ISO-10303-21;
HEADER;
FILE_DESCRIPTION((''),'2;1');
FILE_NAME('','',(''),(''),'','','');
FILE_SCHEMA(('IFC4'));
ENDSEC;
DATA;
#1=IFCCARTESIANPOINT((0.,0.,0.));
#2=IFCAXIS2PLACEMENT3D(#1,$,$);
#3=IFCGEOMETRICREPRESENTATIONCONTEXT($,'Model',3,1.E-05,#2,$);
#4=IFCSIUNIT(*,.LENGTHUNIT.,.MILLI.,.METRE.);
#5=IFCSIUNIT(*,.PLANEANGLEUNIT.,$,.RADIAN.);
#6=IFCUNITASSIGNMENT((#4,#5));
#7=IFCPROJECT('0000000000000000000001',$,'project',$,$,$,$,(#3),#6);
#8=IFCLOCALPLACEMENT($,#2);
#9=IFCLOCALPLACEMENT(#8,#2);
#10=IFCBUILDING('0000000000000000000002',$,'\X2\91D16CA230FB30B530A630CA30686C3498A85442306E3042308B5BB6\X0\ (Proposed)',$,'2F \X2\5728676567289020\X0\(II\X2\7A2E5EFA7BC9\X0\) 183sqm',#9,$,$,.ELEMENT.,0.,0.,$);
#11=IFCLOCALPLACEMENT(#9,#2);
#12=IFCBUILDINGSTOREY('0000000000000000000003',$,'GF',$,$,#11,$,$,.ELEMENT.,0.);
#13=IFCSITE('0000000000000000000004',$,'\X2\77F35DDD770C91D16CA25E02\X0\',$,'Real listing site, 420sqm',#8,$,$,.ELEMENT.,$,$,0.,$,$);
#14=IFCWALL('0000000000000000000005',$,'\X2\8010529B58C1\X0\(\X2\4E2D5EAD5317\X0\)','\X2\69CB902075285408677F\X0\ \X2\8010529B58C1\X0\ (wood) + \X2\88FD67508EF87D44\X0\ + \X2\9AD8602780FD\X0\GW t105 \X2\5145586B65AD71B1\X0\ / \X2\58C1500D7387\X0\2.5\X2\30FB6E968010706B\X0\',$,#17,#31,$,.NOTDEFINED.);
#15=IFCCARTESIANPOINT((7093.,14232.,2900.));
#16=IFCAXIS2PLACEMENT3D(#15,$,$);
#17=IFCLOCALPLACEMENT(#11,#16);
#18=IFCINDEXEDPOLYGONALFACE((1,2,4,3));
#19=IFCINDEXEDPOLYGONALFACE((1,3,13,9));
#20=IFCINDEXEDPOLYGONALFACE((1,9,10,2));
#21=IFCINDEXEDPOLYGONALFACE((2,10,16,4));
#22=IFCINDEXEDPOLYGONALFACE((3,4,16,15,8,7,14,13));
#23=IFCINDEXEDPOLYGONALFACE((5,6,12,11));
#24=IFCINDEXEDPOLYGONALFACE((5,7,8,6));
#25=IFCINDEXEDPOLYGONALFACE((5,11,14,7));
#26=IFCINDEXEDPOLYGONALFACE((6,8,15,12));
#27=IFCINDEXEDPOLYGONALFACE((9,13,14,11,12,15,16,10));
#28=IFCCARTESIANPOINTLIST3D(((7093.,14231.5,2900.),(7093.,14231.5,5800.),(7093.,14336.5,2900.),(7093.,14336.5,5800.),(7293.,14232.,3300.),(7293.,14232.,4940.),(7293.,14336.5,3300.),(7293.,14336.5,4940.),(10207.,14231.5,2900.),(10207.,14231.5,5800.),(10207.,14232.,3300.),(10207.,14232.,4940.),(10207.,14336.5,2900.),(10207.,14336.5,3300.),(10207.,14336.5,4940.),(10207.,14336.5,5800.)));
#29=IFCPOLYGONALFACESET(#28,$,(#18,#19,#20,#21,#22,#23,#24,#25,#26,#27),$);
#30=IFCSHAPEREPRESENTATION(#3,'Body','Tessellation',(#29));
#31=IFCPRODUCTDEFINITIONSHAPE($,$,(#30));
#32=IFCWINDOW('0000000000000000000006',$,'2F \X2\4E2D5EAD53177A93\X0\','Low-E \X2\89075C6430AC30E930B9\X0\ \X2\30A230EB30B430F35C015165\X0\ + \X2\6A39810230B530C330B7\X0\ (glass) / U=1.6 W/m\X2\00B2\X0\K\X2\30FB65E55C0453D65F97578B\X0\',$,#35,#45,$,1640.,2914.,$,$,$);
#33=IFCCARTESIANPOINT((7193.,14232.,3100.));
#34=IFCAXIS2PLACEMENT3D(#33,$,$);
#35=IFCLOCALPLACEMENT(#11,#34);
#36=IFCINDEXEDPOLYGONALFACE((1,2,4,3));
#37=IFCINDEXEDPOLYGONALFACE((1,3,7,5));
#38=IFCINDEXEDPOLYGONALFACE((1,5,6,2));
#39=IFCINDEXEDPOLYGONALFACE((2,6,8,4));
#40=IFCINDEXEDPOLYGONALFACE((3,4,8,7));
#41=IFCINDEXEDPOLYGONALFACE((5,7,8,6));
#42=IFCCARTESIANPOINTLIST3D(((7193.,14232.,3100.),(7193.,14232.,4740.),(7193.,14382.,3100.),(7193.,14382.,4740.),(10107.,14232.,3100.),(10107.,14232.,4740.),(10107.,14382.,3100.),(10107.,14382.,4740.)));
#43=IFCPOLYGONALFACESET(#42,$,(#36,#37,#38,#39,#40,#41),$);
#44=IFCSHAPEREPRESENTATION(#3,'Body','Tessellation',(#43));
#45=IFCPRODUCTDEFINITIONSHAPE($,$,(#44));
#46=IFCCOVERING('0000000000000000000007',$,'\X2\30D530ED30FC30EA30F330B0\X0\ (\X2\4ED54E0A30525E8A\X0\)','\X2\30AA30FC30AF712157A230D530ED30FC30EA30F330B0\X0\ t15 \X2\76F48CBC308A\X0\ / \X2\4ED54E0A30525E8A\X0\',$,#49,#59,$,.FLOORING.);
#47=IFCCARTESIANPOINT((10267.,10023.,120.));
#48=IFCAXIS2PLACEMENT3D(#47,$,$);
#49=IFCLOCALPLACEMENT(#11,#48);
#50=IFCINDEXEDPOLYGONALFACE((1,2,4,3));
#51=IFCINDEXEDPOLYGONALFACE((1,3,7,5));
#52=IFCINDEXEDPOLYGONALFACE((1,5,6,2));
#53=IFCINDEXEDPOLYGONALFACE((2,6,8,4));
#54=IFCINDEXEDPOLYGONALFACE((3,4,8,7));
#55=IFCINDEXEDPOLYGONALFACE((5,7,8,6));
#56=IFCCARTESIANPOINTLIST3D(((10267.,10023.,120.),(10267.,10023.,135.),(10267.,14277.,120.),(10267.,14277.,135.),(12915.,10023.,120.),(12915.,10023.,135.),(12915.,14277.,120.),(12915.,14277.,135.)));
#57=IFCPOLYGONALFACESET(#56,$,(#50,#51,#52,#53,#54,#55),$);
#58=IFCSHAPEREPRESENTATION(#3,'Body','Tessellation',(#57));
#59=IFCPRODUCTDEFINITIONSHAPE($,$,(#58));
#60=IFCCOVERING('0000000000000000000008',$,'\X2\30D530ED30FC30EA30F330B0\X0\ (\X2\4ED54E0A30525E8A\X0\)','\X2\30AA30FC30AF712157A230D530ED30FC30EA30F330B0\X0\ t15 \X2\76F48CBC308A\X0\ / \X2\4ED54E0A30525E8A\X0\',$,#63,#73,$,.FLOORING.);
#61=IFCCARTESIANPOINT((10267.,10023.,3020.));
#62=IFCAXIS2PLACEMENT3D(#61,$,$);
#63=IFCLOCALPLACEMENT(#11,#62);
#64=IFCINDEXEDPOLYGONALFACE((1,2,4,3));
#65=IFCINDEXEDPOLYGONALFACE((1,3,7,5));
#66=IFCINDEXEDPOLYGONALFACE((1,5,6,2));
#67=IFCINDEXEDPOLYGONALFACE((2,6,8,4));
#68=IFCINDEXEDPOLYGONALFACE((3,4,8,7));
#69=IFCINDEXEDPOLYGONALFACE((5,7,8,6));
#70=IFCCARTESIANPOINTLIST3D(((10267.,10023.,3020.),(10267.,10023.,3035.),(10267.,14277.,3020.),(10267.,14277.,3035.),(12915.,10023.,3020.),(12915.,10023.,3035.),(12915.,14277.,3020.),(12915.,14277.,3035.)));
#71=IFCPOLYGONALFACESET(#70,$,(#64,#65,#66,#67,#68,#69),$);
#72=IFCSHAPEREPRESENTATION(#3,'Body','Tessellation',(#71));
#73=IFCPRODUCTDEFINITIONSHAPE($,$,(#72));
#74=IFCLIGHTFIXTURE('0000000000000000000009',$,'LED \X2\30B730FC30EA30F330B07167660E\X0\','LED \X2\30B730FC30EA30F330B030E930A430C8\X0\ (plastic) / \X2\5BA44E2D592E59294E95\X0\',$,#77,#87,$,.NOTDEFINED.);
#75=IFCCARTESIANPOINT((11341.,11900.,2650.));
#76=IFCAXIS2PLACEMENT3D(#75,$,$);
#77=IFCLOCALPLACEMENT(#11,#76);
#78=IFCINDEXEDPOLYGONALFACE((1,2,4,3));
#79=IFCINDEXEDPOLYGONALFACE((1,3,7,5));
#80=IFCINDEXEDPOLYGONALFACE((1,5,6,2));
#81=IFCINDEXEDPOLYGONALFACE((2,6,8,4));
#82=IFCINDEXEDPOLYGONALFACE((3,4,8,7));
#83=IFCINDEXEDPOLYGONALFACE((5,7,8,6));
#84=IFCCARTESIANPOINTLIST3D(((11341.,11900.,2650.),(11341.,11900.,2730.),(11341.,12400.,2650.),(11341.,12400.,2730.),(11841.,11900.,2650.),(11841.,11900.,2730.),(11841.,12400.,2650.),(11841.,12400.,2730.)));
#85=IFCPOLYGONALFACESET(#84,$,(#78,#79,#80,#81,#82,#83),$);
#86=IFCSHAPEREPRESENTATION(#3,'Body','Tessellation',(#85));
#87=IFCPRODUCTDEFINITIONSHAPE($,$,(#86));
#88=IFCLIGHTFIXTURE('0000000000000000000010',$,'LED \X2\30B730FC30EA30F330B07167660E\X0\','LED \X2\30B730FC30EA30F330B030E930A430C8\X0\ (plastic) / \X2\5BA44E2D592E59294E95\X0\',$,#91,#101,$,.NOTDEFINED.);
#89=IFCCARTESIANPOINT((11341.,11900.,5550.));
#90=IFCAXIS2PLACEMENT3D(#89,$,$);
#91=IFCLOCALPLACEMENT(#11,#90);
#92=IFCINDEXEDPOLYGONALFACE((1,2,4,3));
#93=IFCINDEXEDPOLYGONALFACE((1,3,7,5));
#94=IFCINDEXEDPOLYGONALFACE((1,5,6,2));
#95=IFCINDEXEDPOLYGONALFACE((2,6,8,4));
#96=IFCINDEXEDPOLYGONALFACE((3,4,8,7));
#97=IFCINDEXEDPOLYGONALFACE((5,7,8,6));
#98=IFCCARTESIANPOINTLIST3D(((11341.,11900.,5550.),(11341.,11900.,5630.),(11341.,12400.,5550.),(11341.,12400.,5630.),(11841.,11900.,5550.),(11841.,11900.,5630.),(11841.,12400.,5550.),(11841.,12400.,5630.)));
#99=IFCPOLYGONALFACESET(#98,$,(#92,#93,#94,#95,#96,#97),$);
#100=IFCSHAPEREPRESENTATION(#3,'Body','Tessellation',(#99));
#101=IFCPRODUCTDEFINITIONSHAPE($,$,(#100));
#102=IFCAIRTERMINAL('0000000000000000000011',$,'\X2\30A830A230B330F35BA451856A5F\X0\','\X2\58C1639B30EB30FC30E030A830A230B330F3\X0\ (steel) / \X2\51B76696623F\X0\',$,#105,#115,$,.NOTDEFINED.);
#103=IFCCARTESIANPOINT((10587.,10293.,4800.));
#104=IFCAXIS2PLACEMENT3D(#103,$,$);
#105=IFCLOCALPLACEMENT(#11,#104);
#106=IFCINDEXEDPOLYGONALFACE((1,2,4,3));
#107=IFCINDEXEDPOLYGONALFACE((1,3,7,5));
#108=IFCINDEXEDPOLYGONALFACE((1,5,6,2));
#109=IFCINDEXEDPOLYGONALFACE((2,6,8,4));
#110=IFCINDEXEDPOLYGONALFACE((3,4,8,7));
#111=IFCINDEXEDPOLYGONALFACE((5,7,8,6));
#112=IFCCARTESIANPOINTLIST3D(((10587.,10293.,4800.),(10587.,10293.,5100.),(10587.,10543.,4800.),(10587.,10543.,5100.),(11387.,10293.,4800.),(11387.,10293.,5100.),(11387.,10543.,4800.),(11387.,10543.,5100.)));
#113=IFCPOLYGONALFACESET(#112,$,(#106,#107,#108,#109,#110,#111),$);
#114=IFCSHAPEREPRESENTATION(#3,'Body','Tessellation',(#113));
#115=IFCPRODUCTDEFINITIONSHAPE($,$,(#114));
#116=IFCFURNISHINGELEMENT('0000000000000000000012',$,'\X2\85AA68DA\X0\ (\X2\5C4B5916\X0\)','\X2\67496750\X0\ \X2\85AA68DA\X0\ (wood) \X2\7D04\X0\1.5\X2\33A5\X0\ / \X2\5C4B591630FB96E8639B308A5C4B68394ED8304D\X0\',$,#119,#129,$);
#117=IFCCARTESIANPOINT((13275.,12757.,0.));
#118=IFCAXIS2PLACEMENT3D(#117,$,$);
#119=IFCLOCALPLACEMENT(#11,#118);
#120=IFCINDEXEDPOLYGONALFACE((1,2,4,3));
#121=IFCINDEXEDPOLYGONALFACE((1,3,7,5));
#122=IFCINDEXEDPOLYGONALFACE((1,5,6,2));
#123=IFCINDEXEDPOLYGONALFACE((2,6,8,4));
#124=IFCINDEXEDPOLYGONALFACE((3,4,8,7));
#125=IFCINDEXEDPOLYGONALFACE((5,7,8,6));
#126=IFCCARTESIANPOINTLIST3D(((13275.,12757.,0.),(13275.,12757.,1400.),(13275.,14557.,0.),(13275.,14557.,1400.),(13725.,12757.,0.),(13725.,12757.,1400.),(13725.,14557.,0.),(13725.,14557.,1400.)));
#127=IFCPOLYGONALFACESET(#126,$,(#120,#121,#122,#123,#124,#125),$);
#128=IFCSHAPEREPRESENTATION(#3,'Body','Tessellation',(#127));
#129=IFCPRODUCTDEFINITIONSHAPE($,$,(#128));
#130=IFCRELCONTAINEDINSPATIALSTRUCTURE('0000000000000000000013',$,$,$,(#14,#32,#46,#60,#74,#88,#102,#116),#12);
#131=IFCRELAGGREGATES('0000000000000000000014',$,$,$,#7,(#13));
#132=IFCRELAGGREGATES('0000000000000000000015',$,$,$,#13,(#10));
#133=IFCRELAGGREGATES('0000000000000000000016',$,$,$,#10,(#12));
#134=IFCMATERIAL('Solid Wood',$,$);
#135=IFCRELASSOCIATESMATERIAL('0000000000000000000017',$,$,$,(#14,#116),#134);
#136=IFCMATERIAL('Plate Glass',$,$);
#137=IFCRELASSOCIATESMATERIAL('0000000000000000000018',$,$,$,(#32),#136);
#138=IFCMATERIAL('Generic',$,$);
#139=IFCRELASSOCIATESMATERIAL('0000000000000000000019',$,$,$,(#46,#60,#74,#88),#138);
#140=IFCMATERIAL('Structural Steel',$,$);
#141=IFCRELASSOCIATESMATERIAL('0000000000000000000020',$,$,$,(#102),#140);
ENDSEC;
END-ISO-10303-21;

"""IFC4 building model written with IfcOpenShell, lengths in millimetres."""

from ifc_helpers import new_model, si_unit, frame, frame_2d, origin, place, context, project, spatial, rectangle, extrude, material, element, fill, save


model = new_model("IFC4")

# Units and contexts
model_context = context("Model", 3, precision=1e-05, world=origin())
ifc_project = project(units=[si_unit("LENGTHUNIT", "METRE", prefix="MILLI"), si_unit("PLANEANGLEUNIT", "RADIAN")], contexts=[model_context])

# Site, building, storey
site_placement = place(None, origin())
site = spatial("IfcSite", under=ifc_project, at=site_placement, Name="石川県金沢市", ObjectType="Real listing site, 420sqm", CompositionType="ELEMENT", RefElevation=0.0)
building_placement = place(site_placement, origin())
building = spatial("IfcBuilding", under=site, at=building_placement, Name="金沢・サウナと水風呂のある家 (Proposed)", ObjectType="2F 在来木造(II種建築) 183sqm", CompositionType="ELEMENT", ElevationOfRefHeight=0.0, ElevationOfTerrain=0.0)
storey_placement = place(building_placement, origin())
storey = spatial("IfcBuildingStorey", under=building, at=storey_placement, Name="GF", CompositionType="ELEMENT", Elevation=0.0)

# Shared definitions
ifc_material_1 = material(Name="Solid Wood")

# Wall, opening, window
ifc_material_2 = material(Name="Plate Glass")
wall_1_placement = place(storey_placement, frame((7093.0, 14232.0, 2900.0)))
wall_1 = element("IfcWall", 1, at=wall_1_placement, inside=storey, material=ifc_material_1, Name="耐力壁(中庭北)", Description="構造用合板 耐力壁 (wood) + 製材軸組 + 高性能GW t105 充填断熱 / 壁倍率2.5・準耐火", PredefinedType="NOTDEFINED", context=model_context, shape_type="SweptSolid", body=[
    extrude(rectangle(XDim=3114.0, YDim=105.0, at=frame_2d((1557.0, 52.0))), frame((7093.0, 14232.0, 2900.0)), (0.0, 0.0, 1.0), 2900.0),
])
opening_1_placement = place(storey_placement, frame((7193.0, 14232.0, 3100.0)))
opening_1 = element("IfcOpeningElement", 2, at=opening_1_placement, cuts=wall_1, PredefinedType="NOTDEFINED", context=model_context, shape_type="SweptSolid", body=[
    extrude(rectangle(XDim=2914.0, YDim=150.0, at=frame_2d((1457.0, 75.0))), frame((7193.0, 14232.0, 3100.0)), (0.0, 0.0, 1.0), 1640.0),
])
window_1_placement = place(storey_placement, frame((7193.0, 14232.0, 3100.0)))
window_1 = element("IfcWindow", 3, at=window_1_placement, inside=storey, material=ifc_material_2, Name="2F 中庭北窓", Description="Low-E 複層ガラス アルゴン封入 + 樹脂サッシ (glass) / U=1.6 W/m²K・日射取得型", OverallHeight=1640.0, OverallWidth=2914.0, context=model_context, shape_type="SweptSolid", body=[
    extrude(rectangle(XDim=2914.0, YDim=150.0, at=frame_2d((1457.0, 75.0))), frame((7193.0, 14232.0, 3100.0)), (0.0, 0.0, 1.0), 1640.0),
])
fill(opening_1, window_1)

# Coverings
ifc_material_3 = material(Name="Generic")
covering_1_placement = place(storey_placement, frame((10267.0, 10023.0, 120.0)))
element("IfcCovering", 4, at=covering_1_placement, inside=storey, material=ifc_material_3, Name="フローリング (仕上げ床)", Description="オーク無垢フローリング t15 直貼り / 仕上げ床", PredefinedType="FLOORING", context=model_context, shape_type="SweptSolid", body=[
    extrude(rectangle(XDim=2648.0, YDim=4254.0, at=frame_2d((1324.0, 2127.0))), frame((10267.0, 10023.0, 120.0)), (0.0, 0.0, 1.0), 15.0),
])
covering_2_placement = place(storey_placement, frame((10267.0, 10023.0, 3020.0)))
element("IfcCovering", 5, at=covering_2_placement, inside=storey, material=ifc_material_3, Name="フローリング (仕上げ床)", Description="オーク無垢フローリング t15 直貼り / 仕上げ床", PredefinedType="FLOORING", context=model_context, shape_type="SweptSolid", body=[
    extrude(rectangle(XDim=2648.0, YDim=4254.0, at=frame_2d((1324.0, 2127.0))), frame((10267.0, 10023.0, 3020.0)), (0.0, 0.0, 1.0), 15.0),
])

# Light fixtures
light_fixture_1_placement = place(storey_placement, frame((11341.0, 11900.0, 2650.0)))
element("IfcLightFixture", 6, at=light_fixture_1_placement, inside=storey, material=ifc_material_3, Name="LED シーリング照明", Description="LED シーリングライト (plastic) / 室中央天井", PredefinedType="NOTDEFINED", context=model_context, shape_type="SweptSolid", body=[
    extrude(rectangle(XDim=500.0, YDim=500.0, at=frame_2d((250.0, 250.0))), frame((11341.0, 11900.0, 2650.0)), (0.0, 0.0, 1.0), 80.0),
])
light_fixture_2_placement = place(storey_placement, frame((11341.0, 11900.0, 5550.0)))
element("IfcLightFixture", 7, at=light_fixture_2_placement, inside=storey, material=ifc_material_3, Name="LED シーリング照明", Description="LED シーリングライト (plastic) / 室中央天井", PredefinedType="NOTDEFINED", context=model_context, shape_type="SweptSolid", body=[
    extrude(rectangle(XDim=500.0, YDim=500.0, at=frame_2d((250.0, 250.0))), frame((11341.0, 11900.0, 5550.0)), (0.0, 0.0, 1.0), 80.0),
])

# Air terminal
ifc_material_4 = material(Name="Structural Steel")
air_terminal_placement = place(storey_placement, frame((10587.0, 10293.0, 4800.0)))
element("IfcAirTerminal", 8, at=air_terminal_placement, inside=storey, material=ifc_material_4, Name="エアコン室内機", Description="壁掛ルームエアコン (steel) / 冷暖房", PredefinedType="NOTDEFINED", context=model_context, shape_type="SweptSolid", body=[
    extrude(rectangle(XDim=800.0, YDim=250.0, at=frame_2d((400.0, 125.0))), frame((10587.0, 10293.0, 4800.0)), (0.0, 0.0, 1.0), 300.0),
])

# Furnishing element
furnishing_placement = place(storey_placement, frame((13275.0, 12757.0, 0.0)))
element("IfcFurnishingElement", 9, at=furnishing_placement, inside=storey, material=ifc_material_1, Name="薪棚 (屋外)", Description="杉材 薪棚 (wood) 約1.5㎥ / 屋外・雨掛り屋根付き", context=model_context, shape_type="SweptSolid", body=[
    extrude(rectangle(XDim=450.0, YDim=1800.0, at=frame_2d((225.0, 900.0))), frame((13275.0, 12757.0, 0.0)), (0.0, 0.0, 1.0), 1400.0),
])

save(model, "model.ifc")
